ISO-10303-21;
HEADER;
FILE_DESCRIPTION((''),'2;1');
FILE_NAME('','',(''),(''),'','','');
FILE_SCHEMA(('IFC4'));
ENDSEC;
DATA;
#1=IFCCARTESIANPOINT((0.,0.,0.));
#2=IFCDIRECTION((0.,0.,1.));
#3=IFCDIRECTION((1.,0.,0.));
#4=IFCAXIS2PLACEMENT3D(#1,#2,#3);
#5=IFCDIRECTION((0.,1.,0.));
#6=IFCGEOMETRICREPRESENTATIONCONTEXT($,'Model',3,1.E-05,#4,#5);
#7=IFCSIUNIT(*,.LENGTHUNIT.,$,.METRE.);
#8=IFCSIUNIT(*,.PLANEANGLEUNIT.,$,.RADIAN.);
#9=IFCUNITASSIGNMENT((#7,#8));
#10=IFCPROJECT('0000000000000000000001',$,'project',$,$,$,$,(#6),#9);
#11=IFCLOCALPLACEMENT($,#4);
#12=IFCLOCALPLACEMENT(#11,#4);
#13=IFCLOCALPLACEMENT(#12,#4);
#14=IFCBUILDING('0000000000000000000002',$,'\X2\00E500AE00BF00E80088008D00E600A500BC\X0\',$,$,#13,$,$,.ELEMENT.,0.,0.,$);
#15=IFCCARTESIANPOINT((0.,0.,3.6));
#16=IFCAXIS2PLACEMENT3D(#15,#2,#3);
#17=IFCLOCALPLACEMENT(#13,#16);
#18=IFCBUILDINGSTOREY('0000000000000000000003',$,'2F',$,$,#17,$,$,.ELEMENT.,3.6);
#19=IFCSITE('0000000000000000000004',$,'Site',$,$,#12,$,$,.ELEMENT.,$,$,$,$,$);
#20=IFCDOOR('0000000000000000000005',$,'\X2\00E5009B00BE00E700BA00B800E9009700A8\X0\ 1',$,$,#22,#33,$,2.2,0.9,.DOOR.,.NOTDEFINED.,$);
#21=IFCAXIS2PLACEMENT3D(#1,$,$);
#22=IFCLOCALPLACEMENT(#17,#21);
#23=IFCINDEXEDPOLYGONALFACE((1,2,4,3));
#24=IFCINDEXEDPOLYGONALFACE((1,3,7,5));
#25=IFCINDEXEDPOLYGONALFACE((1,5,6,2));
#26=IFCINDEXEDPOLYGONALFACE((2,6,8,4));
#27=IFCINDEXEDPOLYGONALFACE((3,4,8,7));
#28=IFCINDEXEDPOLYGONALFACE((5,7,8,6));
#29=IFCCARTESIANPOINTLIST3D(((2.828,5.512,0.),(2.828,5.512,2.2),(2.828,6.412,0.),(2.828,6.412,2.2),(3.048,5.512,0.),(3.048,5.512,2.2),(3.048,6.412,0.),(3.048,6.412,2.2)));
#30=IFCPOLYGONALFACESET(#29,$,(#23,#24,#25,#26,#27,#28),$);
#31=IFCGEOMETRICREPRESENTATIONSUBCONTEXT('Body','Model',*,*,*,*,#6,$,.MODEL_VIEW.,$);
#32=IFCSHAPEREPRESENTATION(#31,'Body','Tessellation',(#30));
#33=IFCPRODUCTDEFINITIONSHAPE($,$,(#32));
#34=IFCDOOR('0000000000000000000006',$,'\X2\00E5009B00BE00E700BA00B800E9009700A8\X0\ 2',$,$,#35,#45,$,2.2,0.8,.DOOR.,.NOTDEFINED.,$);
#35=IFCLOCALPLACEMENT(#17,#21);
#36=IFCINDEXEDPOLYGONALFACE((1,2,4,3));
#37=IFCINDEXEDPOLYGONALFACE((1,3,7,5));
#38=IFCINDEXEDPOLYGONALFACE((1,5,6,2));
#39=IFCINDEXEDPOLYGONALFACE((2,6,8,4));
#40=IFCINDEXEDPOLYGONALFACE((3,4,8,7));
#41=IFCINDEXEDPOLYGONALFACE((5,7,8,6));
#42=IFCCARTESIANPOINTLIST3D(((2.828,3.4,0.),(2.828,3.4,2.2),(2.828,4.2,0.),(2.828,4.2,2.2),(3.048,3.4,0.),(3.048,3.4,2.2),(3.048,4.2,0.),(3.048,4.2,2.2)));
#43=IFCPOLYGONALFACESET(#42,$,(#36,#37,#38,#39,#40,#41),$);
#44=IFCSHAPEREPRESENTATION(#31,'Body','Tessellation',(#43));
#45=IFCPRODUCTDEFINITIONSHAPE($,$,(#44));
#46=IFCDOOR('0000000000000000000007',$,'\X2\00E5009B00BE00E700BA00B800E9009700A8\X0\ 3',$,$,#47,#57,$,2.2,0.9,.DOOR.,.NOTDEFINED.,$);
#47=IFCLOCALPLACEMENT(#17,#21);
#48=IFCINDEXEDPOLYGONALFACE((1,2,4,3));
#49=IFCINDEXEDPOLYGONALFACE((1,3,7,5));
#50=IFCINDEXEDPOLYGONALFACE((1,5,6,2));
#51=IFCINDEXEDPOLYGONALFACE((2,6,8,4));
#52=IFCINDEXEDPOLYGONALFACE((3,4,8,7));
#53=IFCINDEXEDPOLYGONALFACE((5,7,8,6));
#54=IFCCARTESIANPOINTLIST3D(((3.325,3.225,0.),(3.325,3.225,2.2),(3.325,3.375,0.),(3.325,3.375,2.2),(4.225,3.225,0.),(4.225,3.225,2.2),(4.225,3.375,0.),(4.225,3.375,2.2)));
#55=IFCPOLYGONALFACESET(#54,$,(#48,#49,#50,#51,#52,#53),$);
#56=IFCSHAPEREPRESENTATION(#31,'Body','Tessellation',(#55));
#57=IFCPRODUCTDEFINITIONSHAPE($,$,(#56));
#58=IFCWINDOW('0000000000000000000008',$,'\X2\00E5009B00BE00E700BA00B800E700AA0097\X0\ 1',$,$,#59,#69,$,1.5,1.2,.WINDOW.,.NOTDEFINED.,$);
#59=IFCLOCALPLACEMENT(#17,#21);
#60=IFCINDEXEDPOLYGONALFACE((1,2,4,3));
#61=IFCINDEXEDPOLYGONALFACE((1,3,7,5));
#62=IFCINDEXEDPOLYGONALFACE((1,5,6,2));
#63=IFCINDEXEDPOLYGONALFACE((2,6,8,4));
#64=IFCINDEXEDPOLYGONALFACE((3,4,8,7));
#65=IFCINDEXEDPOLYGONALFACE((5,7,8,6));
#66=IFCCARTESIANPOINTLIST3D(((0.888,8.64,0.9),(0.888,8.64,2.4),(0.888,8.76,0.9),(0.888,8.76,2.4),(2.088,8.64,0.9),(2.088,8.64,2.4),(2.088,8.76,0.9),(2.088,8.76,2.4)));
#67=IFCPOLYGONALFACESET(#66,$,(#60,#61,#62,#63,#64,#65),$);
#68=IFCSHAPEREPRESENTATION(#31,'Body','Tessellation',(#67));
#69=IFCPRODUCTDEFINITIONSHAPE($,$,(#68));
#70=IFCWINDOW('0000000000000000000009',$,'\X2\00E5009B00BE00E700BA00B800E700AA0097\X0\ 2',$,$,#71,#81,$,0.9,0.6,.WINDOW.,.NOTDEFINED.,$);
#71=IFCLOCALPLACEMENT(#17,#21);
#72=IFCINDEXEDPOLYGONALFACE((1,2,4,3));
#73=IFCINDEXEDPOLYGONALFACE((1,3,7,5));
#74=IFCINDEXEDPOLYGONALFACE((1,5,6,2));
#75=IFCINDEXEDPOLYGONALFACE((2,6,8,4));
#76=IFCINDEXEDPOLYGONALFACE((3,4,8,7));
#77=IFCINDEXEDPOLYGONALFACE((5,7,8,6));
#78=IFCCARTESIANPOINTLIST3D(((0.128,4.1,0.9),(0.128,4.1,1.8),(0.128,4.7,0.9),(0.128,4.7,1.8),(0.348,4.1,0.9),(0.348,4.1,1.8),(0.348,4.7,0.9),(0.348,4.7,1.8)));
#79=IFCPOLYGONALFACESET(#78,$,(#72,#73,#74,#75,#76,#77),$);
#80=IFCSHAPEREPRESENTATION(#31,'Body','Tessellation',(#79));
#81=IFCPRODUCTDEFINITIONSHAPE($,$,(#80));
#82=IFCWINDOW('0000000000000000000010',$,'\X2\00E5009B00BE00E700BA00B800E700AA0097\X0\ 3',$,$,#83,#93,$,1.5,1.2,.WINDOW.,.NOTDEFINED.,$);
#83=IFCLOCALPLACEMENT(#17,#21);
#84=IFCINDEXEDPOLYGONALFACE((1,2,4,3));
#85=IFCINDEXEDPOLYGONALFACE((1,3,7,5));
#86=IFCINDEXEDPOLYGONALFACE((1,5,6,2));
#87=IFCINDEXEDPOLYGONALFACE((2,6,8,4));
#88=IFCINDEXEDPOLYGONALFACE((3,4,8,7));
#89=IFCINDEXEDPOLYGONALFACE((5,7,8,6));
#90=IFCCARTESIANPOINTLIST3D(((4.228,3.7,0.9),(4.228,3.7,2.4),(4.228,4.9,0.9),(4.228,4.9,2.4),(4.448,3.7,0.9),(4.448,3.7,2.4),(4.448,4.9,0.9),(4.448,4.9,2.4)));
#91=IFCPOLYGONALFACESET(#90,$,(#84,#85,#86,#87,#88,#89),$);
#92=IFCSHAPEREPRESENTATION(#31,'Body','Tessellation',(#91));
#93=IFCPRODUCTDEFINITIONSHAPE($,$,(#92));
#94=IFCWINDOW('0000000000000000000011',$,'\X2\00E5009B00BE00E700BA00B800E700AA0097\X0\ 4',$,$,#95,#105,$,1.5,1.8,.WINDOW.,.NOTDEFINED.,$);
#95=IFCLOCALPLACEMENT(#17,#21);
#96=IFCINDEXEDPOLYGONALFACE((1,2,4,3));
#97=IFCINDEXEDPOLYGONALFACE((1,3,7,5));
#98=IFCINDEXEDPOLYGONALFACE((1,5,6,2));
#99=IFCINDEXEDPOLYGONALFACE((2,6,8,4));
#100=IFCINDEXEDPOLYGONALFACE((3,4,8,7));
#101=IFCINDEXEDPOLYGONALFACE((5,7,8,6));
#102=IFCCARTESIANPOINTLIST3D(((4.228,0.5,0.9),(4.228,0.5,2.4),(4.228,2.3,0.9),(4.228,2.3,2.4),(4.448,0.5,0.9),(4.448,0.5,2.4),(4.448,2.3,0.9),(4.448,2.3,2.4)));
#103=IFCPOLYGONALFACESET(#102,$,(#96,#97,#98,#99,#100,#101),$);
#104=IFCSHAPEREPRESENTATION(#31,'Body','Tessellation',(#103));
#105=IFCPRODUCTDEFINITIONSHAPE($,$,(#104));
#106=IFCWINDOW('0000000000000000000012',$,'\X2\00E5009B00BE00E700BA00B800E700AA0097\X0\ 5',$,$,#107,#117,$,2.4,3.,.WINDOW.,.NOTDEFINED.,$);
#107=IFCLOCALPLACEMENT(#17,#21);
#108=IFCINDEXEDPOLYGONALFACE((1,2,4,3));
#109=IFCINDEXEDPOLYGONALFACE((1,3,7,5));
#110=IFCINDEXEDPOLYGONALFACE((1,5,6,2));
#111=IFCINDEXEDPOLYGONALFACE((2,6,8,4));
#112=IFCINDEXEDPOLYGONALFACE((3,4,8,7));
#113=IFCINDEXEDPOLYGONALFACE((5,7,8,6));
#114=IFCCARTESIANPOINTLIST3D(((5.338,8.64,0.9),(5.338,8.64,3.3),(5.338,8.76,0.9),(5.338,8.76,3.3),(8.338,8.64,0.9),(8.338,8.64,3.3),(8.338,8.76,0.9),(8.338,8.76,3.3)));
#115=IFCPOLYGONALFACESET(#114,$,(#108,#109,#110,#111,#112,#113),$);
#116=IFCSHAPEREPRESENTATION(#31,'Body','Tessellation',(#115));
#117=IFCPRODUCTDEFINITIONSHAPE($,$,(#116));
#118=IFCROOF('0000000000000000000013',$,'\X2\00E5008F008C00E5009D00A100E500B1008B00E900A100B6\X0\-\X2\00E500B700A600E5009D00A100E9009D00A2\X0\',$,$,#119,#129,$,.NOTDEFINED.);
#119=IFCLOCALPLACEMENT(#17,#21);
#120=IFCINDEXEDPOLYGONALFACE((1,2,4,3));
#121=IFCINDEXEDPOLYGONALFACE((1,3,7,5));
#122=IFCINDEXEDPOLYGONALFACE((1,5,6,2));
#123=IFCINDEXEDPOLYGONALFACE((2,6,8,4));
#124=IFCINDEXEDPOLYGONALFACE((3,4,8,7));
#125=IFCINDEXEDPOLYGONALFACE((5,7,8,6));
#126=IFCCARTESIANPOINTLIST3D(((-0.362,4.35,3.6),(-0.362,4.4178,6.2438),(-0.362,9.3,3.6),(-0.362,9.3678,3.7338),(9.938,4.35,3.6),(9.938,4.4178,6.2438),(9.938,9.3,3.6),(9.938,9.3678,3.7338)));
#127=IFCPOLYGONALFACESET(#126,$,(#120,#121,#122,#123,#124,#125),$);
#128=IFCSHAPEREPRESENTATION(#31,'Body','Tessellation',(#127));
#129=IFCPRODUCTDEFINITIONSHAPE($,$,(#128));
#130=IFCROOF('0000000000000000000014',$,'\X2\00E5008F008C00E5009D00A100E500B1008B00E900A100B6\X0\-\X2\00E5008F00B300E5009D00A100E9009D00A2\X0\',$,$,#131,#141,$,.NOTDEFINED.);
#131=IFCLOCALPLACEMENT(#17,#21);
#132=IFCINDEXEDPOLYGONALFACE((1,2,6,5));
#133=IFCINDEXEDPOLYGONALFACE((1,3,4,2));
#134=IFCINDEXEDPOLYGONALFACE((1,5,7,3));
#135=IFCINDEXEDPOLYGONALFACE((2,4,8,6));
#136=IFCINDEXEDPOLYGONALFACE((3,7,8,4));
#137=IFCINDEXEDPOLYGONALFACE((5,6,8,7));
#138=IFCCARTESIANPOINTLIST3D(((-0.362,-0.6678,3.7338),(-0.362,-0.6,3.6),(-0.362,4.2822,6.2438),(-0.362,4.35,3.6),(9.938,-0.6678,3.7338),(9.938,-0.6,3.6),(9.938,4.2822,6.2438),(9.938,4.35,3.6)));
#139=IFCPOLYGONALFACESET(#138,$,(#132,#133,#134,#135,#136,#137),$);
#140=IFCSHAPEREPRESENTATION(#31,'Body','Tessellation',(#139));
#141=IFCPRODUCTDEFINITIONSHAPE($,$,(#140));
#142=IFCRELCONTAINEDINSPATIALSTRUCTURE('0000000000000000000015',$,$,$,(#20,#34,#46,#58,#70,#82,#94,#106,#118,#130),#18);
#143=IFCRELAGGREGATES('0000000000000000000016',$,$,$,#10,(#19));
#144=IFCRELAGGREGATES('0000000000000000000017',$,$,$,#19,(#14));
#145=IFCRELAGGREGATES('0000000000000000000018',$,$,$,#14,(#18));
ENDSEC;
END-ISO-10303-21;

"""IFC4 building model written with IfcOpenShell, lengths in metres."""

from ifc_helpers import new_model, si_unit, direction, frame, frame_2d, origin_with_axes, place, context, subcontext, project, spatial, polyline, rectangle, outline, extrude, element, save


model = new_model("IFC4")

# Units and contexts
model_context = context("Model", 3, precision=1e-05, world=origin_with_axes(), true_north=direction((0.0, 1.0, 0.0)))
body_context = subcontext(model_context, "Body", "Model", "MODEL_VIEW")
ifc_project = project(units=[si_unit("LENGTHUNIT", "METRE"), si_unit("PLANEANGLEUNIT", "RADIAN")], contexts=[model_context])

# Site, building, storey
placement = place(None, origin_with_axes())
site_placement = place(placement, origin_with_axes())
site = spatial("IfcSite", under=ifc_project, at=site_placement, Name="Site", CompositionType="ELEMENT")
building_placement = place(site_placement, origin_with_axes())
building = spatial("IfcBuilding", under=site, at=building_placement, Name="å®¿è\u0088\u008dæ¥¼", CompositionType="ELEMENT", ElevationOfRefHeight=0.0, ElevationOfTerrain=0.0)
storey_placement = place(building_placement, frame((0.0, 0.0, 3.6), z_axis=(0.0, 0.0, 1.0), x_axis=(1.0, 0.0, 0.0)))
storey = spatial("IfcBuildingStorey", under=building, at=storey_placement, Name="2F", CompositionType="ELEMENT", Elevation=3.6)

# Doors
door_1_placement = place(storey_placement, frame((2.938, 5.962, 0.0), z_axis=(0.0, 0.0, 1.0), x_axis=(0.0, 1.0, 0.0)))
element("IfcDoor", 1, at=door_1_placement, inside=storey, Name="å\u009b¾çº¸é\u0097¨ 1", OperationType="NOTDEFINED", OverallHeight=2.2, OverallWidth=0.9, PredefinedType="DOOR", context=body_context, shape_type="SweptSolid", body=[
    extrude(rectangle(XDim=0.9, YDim=0.22, at=frame_2d((0.0, 0.0), x_axis=(1.0, 0.0, 0.0))), frame((0.0, 0.0, 0.0), z_axis=(0.0, 0.0, 1.0)), (0.0, 0.0, 1.0), 2.2),
])
door_2_placement = place(storey_placement, frame((2.938, 3.8, 0.0), z_axis=(0.0, 0.0, 1.0), x_axis=(0.0, 1.0, 0.0)))
element("IfcDoor", 2, at=door_2_placement, inside=storey, Name="å\u009b¾çº¸é\u0097¨ 2", OperationType="NOTDEFINED", OverallHeight=2.2, OverallWidth=0.8, PredefinedType="DOOR", context=body_context, shape_type="SweptSolid", body=[
    extrude(rectangle(XDim=0.8, YDim=0.22, at=frame_2d((0.0, 0.0), x_axis=(1.0, 0.0, 0.0))), frame((0.0, 0.0, 0.0), z_axis=(0.0, 0.0, 1.0)), (0.0, 0.0, 1.0), 2.2),
])
door_3_placement = place(storey_placement, frame((3.775, 3.3, 0.0), z_axis=(0.0, 0.0, 1.0), x_axis=(1.0, 0.0, 0.0)))
element("IfcDoor", 3, at=door_3_placement, inside=storey, Name="å\u009b¾çº¸é\u0097¨ 3", OperationType="NOTDEFINED", OverallHeight=2.2, OverallWidth=0.9, PredefinedType="DOOR", context=body_context, shape_type="SweptSolid", body=[
    extrude(rectangle(XDim=0.9, YDim=0.15, at=frame_2d((0.0, 0.0), x_axis=(1.0, 0.0, 0.0))), frame((0.0, 0.0, 0.0), z_axis=(0.0, 0.0, 1.0)), (0.0, 0.0, 1.0), 2.2),
])

# Windows
window_1_placement = place(storey_placement, frame((1.488, 8.7, 0.9), z_axis=(0.0, 0.0, 1.0), x_axis=(1.0, 0.0, 0.0)))
element("IfcWindow", 4, at=window_1_placement, inside=storey, Name="å\u009b¾çº¸çª\u0097 1", OverallHeight=1.5, OverallWidth=1.2, PartitioningType="NOTDEFINED", PredefinedType="WINDOW", context=body_context, shape_type="SweptSolid", body=[
    extrude(rectangle(XDim=1.2, YDim=0.12, at=frame_2d((0.0, 0.0), x_axis=(1.0, 0.0, 0.0))), frame((0.0, 0.0, 0.0), z_axis=(0.0, 0.0, 1.0)), (0.0, 0.0, 1.0), 1.5),
])
window_2_placement = place(storey_placement, frame((0.238, 4.4, 0.9), z_axis=(0.0, 0.0, 1.0), x_axis=(0.0, 1.0, 0.0)))
element("IfcWindow", 5, at=window_2_placement, inside=storey, Name="å\u009b¾çº¸çª\u0097 2", OverallHeight=0.9, OverallWidth=0.6, PartitioningType="NOTDEFINED", PredefinedType="WINDOW", context=body_context, shape_type="SweptSolid", body=[
    extrude(rectangle(XDim=0.6, YDim=0.22, at=frame_2d((0.0, 0.0), x_axis=(1.0, 0.0, 0.0))), frame((0.0, 0.0, 0.0), z_axis=(0.0, 0.0, 1.0)), (0.0, 0.0, 1.0), 0.9),
])
window_3_placement = place(storey_placement, frame((4.338, 4.3, 0.9), z_axis=(0.0, 0.0, 1.0), x_axis=(0.0, 1.0, 0.0)))
element("IfcWindow", 6, at=window_3_placement, inside=storey, Name="å\u009b¾çº¸çª\u0097 3", OverallHeight=1.5, OverallWidth=1.2, PartitioningType="NOTDEFINED", PredefinedType="WINDOW", context=body_context, shape_type="SweptSolid", body=[
    extrude(rectangle(XDim=1.2, YDim=0.22, at=frame_2d((0.0, 0.0), x_axis=(1.0, 0.0, 0.0))), frame((0.0, 0.0, 0.0), z_axis=(0.0, 0.0, 1.0)), (0.0, 0.0, 1.0), 1.5),
])
window_4_placement = place(storey_placement, frame((4.338, 1.4, 0.9), z_axis=(0.0, 0.0, 1.0), x_axis=(0.0, 1.0, 0.0)))
element("IfcWindow", 7, at=window_4_placement, inside=storey, Name="å\u009b¾çº¸çª\u0097 4", OverallHeight=1.5, OverallWidth=1.8, PartitioningType="NOTDEFINED", PredefinedType="WINDOW", context=body_context, shape_type="SweptSolid", body=[
    extrude(rectangle(XDim=1.8, YDim=0.22, at=frame_2d((0.0, 0.0), x_axis=(1.0, 0.0, 0.0))), frame((0.0, 0.0, 0.0), z_axis=(0.0, 0.0, 1.0)), (0.0, 0.0, 1.0), 1.5),
])
window_5_placement = place(storey_placement, frame((6.838, 8.7, 0.9), z_axis=(0.0, 0.0, 1.0), x_axis=(-1.0, 0.0, 0.0)))
element("IfcWindow", 8, at=window_5_placement, inside=storey, Name="å\u009b¾çº¸çª\u0097 5", OverallHeight=2.4, OverallWidth=3.0, PartitioningType="NOTDEFINED", PredefinedType="WINDOW", context=body_context, shape_type="SweptSolid", body=[
    extrude(rectangle(XDim=3.0, YDim=0.12, at=frame_2d((0.0, 0.0), x_axis=(1.0, 0.0, 0.0))), frame((0.0, 0.0, 0.0), z_axis=(0.0, 0.0, 1.0)), (0.0, 0.0, 1.0), 2.4),
])

# Roofs
roof_1_placement = place(storey_placement, frame((4.788, 4.35, 3.6), z_axis=(0.0, 0.0, 1.0), x_axis=(1.0, 0.0, 0.0)))
element("IfcRoof", 9, at=roof_1_placement, inside=storey, Name="å\u008f\u008cå\u009d¡å±\u008bé¡¶-å·¦å\u009d¡é\u009d¢", PredefinedType="NOTDEFINED", context=body_context, shape_type="SweptSolid", body=[
    extrude(outline(polyline([(0.0, 0.0), (4.95, 0.0), (5.0178, 0.1338), (0.0678, 2.6438), (0.0, 0.0)])), frame((-5.15, 0.0, 0.0), z_axis=(1.0, 0.0, 0.0), x_axis=(0.0, 1.0, 0.0)), (0.0, 0.0, 1.0), 10.3),
])
roof_2_placement = place(storey_placement, frame((4.788, 4.35, 3.6), z_axis=(0.0, 0.0, 1.0), x_axis=(1.0, 0.0, 0.0)))
element("IfcRoof", 10, at=roof_2_placement, inside=storey, Name="å\u008f\u008cå\u009d¡å±\u008bé¡¶-å\u008f³å\u009d¡é\u009d¢", PredefinedType="NOTDEFINED", context=body_context, shape_type="SweptSolid", body=[
    extrude(outline(polyline([(0.0, 0.0), (-4.95, 0.0), (-5.0178, 0.1338), (-0.0678, 2.6438), (0.0, 0.0)])), frame((-5.15, 0.0, 0.0), z_axis=(1.0, 0.0, 0.0), x_axis=(0.0, 1.0, 0.0)), (0.0, 0.0, 1.0), 10.3),
])

save(model, "model.ifc")
